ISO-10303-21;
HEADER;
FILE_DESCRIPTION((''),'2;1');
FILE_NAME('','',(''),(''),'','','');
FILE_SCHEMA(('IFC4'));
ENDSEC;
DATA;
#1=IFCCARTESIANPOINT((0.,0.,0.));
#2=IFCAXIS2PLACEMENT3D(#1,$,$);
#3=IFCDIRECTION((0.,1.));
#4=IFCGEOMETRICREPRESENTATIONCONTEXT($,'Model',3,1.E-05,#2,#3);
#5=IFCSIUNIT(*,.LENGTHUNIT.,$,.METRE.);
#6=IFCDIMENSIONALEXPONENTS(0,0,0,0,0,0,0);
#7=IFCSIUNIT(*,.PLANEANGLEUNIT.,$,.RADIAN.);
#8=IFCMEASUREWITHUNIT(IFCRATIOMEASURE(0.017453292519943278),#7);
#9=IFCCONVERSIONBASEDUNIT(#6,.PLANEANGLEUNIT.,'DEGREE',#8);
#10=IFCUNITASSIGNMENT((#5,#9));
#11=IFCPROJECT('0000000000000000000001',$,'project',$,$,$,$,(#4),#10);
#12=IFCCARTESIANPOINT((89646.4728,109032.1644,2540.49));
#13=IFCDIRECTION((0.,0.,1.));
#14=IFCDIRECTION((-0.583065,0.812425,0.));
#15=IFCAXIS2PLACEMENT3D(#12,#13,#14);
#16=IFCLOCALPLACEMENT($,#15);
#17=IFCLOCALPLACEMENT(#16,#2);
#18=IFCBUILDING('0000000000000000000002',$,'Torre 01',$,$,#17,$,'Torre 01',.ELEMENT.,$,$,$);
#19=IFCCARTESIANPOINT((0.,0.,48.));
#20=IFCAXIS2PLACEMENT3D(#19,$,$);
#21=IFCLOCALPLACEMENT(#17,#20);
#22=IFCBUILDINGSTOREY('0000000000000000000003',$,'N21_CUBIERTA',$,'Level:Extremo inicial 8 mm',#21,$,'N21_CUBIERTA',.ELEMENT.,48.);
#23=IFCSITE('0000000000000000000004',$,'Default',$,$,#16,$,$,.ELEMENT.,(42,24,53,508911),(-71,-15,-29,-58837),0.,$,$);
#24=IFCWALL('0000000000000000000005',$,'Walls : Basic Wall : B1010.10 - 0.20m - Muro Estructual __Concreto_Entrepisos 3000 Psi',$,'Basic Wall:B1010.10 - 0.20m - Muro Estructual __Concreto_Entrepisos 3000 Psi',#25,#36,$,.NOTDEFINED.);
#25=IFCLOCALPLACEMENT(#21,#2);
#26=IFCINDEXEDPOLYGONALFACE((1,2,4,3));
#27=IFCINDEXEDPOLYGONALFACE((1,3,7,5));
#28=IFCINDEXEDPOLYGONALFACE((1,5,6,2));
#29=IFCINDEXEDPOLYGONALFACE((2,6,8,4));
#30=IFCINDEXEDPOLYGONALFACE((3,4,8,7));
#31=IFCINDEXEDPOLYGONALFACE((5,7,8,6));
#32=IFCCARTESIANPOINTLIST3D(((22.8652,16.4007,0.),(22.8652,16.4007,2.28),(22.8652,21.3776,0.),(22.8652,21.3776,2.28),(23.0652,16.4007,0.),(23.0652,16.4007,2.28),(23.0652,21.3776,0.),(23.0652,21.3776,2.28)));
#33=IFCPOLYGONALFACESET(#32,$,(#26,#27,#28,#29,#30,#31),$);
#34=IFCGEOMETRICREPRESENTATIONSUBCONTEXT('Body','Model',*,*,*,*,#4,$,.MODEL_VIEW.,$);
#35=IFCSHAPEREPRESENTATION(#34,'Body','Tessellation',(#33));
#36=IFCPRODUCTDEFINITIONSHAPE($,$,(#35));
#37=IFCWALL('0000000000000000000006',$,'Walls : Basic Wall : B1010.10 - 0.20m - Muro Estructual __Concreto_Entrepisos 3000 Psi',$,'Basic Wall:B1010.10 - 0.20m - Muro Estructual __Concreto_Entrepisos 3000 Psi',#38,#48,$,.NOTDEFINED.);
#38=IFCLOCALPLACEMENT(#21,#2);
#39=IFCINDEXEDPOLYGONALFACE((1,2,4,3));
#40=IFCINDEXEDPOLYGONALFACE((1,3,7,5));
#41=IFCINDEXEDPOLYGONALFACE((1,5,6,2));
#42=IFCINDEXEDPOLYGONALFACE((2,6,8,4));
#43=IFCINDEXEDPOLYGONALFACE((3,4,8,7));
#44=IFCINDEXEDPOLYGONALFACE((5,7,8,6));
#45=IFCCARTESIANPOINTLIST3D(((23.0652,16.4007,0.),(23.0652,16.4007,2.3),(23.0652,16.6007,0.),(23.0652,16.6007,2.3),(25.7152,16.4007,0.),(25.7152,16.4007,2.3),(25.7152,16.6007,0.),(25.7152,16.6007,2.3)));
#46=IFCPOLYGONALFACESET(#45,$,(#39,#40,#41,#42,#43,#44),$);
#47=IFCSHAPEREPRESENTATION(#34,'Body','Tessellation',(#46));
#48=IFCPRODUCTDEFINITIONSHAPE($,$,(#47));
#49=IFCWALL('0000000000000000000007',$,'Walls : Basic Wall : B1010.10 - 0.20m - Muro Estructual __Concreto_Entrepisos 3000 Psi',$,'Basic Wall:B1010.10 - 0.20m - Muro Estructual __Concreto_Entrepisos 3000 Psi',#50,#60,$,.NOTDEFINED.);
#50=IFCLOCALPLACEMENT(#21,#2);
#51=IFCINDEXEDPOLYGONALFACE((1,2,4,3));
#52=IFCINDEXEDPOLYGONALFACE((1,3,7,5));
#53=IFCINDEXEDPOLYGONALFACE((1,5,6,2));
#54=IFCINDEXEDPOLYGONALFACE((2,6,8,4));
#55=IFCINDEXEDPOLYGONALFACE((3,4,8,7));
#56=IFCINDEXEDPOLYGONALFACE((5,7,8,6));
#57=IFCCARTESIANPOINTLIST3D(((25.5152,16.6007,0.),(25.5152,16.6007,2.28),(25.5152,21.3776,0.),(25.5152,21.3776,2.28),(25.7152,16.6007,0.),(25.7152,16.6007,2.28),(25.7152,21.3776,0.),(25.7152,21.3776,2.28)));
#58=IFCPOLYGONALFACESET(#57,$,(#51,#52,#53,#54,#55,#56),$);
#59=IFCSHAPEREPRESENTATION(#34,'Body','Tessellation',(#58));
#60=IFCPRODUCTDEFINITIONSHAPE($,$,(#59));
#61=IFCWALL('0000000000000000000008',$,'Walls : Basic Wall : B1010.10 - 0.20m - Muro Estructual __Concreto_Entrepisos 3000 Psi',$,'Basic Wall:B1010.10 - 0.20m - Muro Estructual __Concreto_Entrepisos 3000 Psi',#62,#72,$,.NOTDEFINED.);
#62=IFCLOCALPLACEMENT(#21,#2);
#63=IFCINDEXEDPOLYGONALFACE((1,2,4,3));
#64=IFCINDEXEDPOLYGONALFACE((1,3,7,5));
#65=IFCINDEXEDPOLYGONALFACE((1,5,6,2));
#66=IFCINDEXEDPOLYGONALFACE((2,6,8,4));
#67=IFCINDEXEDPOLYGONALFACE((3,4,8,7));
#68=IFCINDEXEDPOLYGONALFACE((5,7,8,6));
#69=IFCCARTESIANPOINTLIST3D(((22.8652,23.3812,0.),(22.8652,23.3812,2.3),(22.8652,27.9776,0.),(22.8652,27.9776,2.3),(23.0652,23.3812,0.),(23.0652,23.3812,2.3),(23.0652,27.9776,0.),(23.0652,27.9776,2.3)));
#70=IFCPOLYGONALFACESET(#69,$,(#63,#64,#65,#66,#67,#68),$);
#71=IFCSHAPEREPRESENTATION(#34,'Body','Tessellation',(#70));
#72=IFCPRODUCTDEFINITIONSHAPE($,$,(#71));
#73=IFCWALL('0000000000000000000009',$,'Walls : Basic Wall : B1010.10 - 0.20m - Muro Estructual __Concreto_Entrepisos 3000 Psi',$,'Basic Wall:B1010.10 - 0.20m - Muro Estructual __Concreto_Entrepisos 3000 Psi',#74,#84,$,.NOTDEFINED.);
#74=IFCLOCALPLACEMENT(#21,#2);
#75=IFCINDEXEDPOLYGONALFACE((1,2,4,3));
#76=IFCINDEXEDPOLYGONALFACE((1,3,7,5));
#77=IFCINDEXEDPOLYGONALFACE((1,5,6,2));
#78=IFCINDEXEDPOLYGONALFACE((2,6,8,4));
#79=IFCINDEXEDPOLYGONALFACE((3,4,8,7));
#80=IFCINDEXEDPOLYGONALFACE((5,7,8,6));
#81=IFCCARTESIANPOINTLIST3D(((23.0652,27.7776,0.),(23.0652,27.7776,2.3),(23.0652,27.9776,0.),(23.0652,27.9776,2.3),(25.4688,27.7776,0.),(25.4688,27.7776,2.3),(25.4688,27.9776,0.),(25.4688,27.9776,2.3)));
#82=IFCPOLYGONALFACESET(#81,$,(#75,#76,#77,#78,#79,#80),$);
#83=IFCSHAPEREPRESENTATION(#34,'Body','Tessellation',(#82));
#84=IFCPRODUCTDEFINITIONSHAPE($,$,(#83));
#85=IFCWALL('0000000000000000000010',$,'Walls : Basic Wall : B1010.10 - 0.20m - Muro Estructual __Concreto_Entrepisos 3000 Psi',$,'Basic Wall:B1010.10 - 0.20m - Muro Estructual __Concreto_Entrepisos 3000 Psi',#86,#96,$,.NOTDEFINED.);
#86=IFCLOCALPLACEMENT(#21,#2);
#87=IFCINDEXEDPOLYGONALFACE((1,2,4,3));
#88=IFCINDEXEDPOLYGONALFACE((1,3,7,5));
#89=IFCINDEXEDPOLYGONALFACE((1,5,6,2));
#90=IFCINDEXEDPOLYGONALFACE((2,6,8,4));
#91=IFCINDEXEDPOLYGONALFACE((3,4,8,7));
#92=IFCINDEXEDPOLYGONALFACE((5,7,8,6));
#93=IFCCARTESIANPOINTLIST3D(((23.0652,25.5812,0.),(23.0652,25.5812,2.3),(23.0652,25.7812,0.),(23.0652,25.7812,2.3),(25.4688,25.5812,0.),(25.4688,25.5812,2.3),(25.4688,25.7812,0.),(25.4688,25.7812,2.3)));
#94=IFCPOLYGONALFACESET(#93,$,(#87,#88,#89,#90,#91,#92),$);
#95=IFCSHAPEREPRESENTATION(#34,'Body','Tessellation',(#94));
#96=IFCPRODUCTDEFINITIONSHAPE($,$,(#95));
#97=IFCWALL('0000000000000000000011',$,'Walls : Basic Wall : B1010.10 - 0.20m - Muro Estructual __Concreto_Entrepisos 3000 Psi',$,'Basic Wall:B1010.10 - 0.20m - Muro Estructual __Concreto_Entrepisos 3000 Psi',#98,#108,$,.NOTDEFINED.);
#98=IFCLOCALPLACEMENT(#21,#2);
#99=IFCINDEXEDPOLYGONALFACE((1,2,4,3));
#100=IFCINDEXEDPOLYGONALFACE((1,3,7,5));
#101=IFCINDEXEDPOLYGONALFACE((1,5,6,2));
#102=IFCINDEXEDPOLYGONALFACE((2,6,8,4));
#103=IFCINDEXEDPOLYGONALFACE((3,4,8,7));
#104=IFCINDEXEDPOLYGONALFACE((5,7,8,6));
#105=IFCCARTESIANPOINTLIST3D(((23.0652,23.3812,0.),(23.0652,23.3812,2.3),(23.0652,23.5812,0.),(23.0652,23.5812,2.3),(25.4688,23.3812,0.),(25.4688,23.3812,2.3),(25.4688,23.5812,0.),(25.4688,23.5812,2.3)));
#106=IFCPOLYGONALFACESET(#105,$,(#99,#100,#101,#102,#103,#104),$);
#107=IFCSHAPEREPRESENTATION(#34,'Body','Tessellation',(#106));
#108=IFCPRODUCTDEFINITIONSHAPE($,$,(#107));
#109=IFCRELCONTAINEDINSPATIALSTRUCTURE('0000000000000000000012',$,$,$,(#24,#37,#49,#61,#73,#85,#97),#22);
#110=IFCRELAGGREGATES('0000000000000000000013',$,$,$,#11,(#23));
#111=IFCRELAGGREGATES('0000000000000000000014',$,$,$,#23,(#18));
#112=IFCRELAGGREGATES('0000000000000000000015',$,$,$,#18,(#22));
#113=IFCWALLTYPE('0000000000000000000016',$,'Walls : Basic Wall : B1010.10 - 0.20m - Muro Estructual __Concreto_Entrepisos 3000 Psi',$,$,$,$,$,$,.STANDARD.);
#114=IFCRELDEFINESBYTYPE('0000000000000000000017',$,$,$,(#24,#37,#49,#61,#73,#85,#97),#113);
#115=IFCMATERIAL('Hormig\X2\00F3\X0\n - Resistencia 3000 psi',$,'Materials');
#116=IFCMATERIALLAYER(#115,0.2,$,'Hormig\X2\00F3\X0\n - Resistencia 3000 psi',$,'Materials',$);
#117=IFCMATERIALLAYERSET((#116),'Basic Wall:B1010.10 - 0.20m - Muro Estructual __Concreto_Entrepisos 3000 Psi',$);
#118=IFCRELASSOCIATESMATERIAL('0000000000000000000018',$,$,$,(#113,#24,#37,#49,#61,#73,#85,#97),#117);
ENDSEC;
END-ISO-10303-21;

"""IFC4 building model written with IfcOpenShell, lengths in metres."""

from ifc_helpers import new_model, entity, si_unit, converted_unit, direction, frame, frame_2d, origin, place, context, subcontext, project, spatial, rectangle, extrude, material, layer, layer_set, layer_usage, type_object, element, save


model = new_model("IFC4")

# Units and contexts
model_context = context("Model", 3, precision=1e-05, world=origin(), true_north=direction((0.0, 1.0)))
body_context = subcontext(model_context, "Body", "Model", "MODEL_VIEW")
ifc_project = project(units=[si_unit("LENGTHUNIT", "METRE"), converted_unit("PLANEANGLEUNIT", "DEGREE", entity("IfcRatioMeasure", 0.017453292519943278), si_unit("PLANEANGLEUNIT", "RADIAN"), dimensions=[0, 0, 0, 0, 0, 0, 0])], contexts=[model_context])

# Site, building, storey
site_placement = place(None, frame((89646.4728, 109032.1644, 2540.49), z_axis=(0.0, 0.0, 1.0), x_axis=(-0.583065, 0.812425, 0.0)))
site = spatial("IfcSite", under=ifc_project, at=site_placement, Name="Default", CompositionType="ELEMENT", RefLatitude=(42, 24, 53, 508911), RefLongitude=(-71, -15, -29, -58837), RefElevation=0.0)
building_placement = place(site_placement, origin())
building = spatial("IfcBuilding", under=site, at=building_placement, Name="Torre 01", LongName="Torre 01", CompositionType="ELEMENT")
storey_placement = place(building_placement, frame((0.0, 0.0, 48.0)))
storey = spatial("IfcBuildingStorey", under=building, at=storey_placement, Name="N21_CUBIERTA", ObjectType="Level:Extremo inicial 8 mm", LongName="N21_CUBIERTA", CompositionType="ELEMENT", Elevation=48.0)

# Walls
ifc_material_1 = material(Name="Hormigón - Resistencia 3000 psi", Category="Materials")
ifc_layer_1 = layer(ifc_material_1, 0.2, Name="Hormigón - Resistencia 3000 psi", Category="Materials")
ifc_layer_set_1 = layer_set([ifc_layer_1], Name="Basic Wall:B1010.10 - 0.20m - Muro Estructual __Concreto_Entrepisos 3000 Psi")
ifc_layer_usage_1 = layer_usage(ifc_layer_set_1, "AXIS2", "NEGATIVE", 0.1)
wall_type = type_object("IfcWallType", Name="Walls : Basic Wall : B1010.10 - 0.20m - Muro Estructual __Concreto_Entrepisos 3000 Psi", PredefinedType="STANDARD", material=ifc_layer_set_1)
wall_1_placement = place(storey_placement, frame((22.9652, 21.3776, 0.0), z_axis=(0.0, 0.0, 1.0), x_axis=(0.0, -1.0, 0.0)))
element("IfcWall", 1, at=wall_1_placement, inside=storey, type_object=wall_type, material=ifc_layer_usage_1, Name="Walls : Basic Wall : B1010.10 - 0.20m - Muro Estructual __Concreto_Entrepisos 3000 Psi", ObjectType="Basic Wall:B1010.10 - 0.20m - Muro Estructual __Concreto_Entrepisos 3000 Psi", PredefinedType="NOTDEFINED", context=body_context, shape_type="SweptSolid", body=[
    extrude(rectangle(XDim=4.9769, YDim=0.2, at=frame_2d((2.4884, 0.0), x_axis=(-1.0, 0.0))), origin(), (0.0, 0.0, 1.0), 2.28),
])
ifc_layer_usage_2 = layer_usage(ifc_layer_set_1, "AXIS2", "NEGATIVE", 0.1)
wall_2_placement = place(storey_placement, frame((23.0652, 16.5007, 0.0)))
element("IfcWall", 2, at=wall_2_placement, inside=storey, type_object=wall_type, material=ifc_layer_usage_2, Name="Walls : Basic Wall : B1010.10 - 0.20m - Muro Estructual __Concreto_Entrepisos 3000 Psi", ObjectType="Basic Wall:B1010.10 - 0.20m - Muro Estructual __Concreto_Entrepisos 3000 Psi", PredefinedType="NOTDEFINED", context=body_context, shape_type="SweptSolid", body=[
    extrude(rectangle(XDim=2.65, YDim=0.2, at=frame_2d((1.325, 0.0), x_axis=(-1.0, 0.0))), origin(), (0.0, 0.0, 1.0), 2.3),
])
ifc_layer_usage_3 = layer_usage(ifc_layer_set_1, "AXIS2", "NEGATIVE", 0.1)
wall_3_placement = place(storey_placement, frame((25.6152, 16.6007, 0.0), z_axis=(0.0, 0.0, 1.0), x_axis=(0.0, 1.0, 0.0)))
element("IfcWall", 3, at=wall_3_placement, inside=storey, type_object=wall_type, material=ifc_layer_usage_3, Name="Walls : Basic Wall : B1010.10 - 0.20m - Muro Estructual __Concreto_Entrepisos 3000 Psi", ObjectType="Basic Wall:B1010.10 - 0.20m - Muro Estructual __Concreto_Entrepisos 3000 Psi", PredefinedType="NOTDEFINED", context=body_context, shape_type="SweptSolid", body=[
    extrude(rectangle(XDim=4.7769, YDim=0.2, at=frame_2d((2.3884, 0.0), x_axis=(-1.0, 0.0))), origin(), (0.0, 0.0, 1.0), 2.28),
])
ifc_layer_usage_4 = layer_usage(ifc_layer_set_1, "AXIS2", "NEGATIVE", 0.1)
wall_4_placement = place(storey_placement, frame((22.9652, 23.3812, 0.0), z_axis=(0.0, 0.0, 1.0), x_axis=(0.0, 1.0, 0.0)))
element("IfcWall", 4, at=wall_4_placement, inside=storey, type_object=wall_type, material=ifc_layer_usage_4, Name="Walls : Basic Wall : B1010.10 - 0.20m - Muro Estructual __Concreto_Entrepisos 3000 Psi", ObjectType="Basic Wall:B1010.10 - 0.20m - Muro Estructual __Concreto_Entrepisos 3000 Psi", PredefinedType="NOTDEFINED", context=body_context, shape_type="SweptSolid", body=[
    extrude(rectangle(XDim=4.5964, YDim=0.2, at=frame_2d((2.2982, 0.0), x_axis=(-1.0, 0.0))), origin(), (0.0, 0.0, 1.0), 2.3),
])
ifc_layer_usage_5 = layer_usage(ifc_layer_set_1, "AXIS2", "NEGATIVE", 0.1)
wall_5_placement = place(storey_placement, frame((23.0652, 27.8776, 0.0)))
element("IfcWall", 5, at=wall_5_placement, inside=storey, type_object=wall_type, material=ifc_layer_usage_5, Name="Walls : Basic Wall : B1010.10 - 0.20m - Muro Estructual __Concreto_Entrepisos 3000 Psi", ObjectType="Basic Wall:B1010.10 - 0.20m - Muro Estructual __Concreto_Entrepisos 3000 Psi", PredefinedType="NOTDEFINED", context=body_context, shape_type="SweptSolid", body=[
    extrude(rectangle(XDim=2.4037, YDim=0.2, at=frame_2d((1.2018, 0.0), x_axis=(-1.0, 0.0))), origin(), (0.0, 0.0, 1.0), 2.3),
])
ifc_layer_usage_6 = layer_usage(ifc_layer_set_1, "AXIS2", "NEGATIVE", 0.1)
wall_6_placement = place(storey_placement, frame((23.0652, 25.6812, 0.0)))
element("IfcWall", 6, at=wall_6_placement, inside=storey, type_object=wall_type, material=ifc_layer_usage_6, Name="Walls : Basic Wall : B1010.10 - 0.20m - Muro Estructual __Concreto_Entrepisos 3000 Psi", ObjectType="Basic Wall:B1010.10 - 0.20m - Muro Estructual __Concreto_Entrepisos 3000 Psi", PredefinedType="NOTDEFINED", context=body_context, shape_type="SweptSolid", body=[
    extrude(rectangle(XDim=2.4037, YDim=0.2, at=frame_2d((1.2018, 0.0), x_axis=(-1.0, 0.0))), origin(), (0.0, 0.0, 1.0), 2.3),
])
ifc_layer_usage_7 = layer_usage(ifc_layer_set_1, "AXIS2", "NEGATIVE", 0.1)
wall_7_placement = place(storey_placement, frame((23.0652, 23.4812, 0.0)))
element("IfcWall", 7, at=wall_7_placement, inside=storey, type_object=wall_type, material=ifc_layer_usage_7, Name="Walls : Basic Wall : B1010.10 - 0.20m - Muro Estructual __Concreto_Entrepisos 3000 Psi", ObjectType="Basic Wall:B1010.10 - 0.20m - Muro Estructual __Concreto_Entrepisos 3000 Psi", PredefinedType="NOTDEFINED", context=body_context, shape_type="SweptSolid", body=[
    extrude(rectangle(XDim=2.4037, YDim=0.2, at=frame_2d((1.2018, 0.0), x_axis=(-1.0, 0.0))), origin(), (0.0, 0.0, 1.0), 2.3),
])

save(model, "model.ifc")
